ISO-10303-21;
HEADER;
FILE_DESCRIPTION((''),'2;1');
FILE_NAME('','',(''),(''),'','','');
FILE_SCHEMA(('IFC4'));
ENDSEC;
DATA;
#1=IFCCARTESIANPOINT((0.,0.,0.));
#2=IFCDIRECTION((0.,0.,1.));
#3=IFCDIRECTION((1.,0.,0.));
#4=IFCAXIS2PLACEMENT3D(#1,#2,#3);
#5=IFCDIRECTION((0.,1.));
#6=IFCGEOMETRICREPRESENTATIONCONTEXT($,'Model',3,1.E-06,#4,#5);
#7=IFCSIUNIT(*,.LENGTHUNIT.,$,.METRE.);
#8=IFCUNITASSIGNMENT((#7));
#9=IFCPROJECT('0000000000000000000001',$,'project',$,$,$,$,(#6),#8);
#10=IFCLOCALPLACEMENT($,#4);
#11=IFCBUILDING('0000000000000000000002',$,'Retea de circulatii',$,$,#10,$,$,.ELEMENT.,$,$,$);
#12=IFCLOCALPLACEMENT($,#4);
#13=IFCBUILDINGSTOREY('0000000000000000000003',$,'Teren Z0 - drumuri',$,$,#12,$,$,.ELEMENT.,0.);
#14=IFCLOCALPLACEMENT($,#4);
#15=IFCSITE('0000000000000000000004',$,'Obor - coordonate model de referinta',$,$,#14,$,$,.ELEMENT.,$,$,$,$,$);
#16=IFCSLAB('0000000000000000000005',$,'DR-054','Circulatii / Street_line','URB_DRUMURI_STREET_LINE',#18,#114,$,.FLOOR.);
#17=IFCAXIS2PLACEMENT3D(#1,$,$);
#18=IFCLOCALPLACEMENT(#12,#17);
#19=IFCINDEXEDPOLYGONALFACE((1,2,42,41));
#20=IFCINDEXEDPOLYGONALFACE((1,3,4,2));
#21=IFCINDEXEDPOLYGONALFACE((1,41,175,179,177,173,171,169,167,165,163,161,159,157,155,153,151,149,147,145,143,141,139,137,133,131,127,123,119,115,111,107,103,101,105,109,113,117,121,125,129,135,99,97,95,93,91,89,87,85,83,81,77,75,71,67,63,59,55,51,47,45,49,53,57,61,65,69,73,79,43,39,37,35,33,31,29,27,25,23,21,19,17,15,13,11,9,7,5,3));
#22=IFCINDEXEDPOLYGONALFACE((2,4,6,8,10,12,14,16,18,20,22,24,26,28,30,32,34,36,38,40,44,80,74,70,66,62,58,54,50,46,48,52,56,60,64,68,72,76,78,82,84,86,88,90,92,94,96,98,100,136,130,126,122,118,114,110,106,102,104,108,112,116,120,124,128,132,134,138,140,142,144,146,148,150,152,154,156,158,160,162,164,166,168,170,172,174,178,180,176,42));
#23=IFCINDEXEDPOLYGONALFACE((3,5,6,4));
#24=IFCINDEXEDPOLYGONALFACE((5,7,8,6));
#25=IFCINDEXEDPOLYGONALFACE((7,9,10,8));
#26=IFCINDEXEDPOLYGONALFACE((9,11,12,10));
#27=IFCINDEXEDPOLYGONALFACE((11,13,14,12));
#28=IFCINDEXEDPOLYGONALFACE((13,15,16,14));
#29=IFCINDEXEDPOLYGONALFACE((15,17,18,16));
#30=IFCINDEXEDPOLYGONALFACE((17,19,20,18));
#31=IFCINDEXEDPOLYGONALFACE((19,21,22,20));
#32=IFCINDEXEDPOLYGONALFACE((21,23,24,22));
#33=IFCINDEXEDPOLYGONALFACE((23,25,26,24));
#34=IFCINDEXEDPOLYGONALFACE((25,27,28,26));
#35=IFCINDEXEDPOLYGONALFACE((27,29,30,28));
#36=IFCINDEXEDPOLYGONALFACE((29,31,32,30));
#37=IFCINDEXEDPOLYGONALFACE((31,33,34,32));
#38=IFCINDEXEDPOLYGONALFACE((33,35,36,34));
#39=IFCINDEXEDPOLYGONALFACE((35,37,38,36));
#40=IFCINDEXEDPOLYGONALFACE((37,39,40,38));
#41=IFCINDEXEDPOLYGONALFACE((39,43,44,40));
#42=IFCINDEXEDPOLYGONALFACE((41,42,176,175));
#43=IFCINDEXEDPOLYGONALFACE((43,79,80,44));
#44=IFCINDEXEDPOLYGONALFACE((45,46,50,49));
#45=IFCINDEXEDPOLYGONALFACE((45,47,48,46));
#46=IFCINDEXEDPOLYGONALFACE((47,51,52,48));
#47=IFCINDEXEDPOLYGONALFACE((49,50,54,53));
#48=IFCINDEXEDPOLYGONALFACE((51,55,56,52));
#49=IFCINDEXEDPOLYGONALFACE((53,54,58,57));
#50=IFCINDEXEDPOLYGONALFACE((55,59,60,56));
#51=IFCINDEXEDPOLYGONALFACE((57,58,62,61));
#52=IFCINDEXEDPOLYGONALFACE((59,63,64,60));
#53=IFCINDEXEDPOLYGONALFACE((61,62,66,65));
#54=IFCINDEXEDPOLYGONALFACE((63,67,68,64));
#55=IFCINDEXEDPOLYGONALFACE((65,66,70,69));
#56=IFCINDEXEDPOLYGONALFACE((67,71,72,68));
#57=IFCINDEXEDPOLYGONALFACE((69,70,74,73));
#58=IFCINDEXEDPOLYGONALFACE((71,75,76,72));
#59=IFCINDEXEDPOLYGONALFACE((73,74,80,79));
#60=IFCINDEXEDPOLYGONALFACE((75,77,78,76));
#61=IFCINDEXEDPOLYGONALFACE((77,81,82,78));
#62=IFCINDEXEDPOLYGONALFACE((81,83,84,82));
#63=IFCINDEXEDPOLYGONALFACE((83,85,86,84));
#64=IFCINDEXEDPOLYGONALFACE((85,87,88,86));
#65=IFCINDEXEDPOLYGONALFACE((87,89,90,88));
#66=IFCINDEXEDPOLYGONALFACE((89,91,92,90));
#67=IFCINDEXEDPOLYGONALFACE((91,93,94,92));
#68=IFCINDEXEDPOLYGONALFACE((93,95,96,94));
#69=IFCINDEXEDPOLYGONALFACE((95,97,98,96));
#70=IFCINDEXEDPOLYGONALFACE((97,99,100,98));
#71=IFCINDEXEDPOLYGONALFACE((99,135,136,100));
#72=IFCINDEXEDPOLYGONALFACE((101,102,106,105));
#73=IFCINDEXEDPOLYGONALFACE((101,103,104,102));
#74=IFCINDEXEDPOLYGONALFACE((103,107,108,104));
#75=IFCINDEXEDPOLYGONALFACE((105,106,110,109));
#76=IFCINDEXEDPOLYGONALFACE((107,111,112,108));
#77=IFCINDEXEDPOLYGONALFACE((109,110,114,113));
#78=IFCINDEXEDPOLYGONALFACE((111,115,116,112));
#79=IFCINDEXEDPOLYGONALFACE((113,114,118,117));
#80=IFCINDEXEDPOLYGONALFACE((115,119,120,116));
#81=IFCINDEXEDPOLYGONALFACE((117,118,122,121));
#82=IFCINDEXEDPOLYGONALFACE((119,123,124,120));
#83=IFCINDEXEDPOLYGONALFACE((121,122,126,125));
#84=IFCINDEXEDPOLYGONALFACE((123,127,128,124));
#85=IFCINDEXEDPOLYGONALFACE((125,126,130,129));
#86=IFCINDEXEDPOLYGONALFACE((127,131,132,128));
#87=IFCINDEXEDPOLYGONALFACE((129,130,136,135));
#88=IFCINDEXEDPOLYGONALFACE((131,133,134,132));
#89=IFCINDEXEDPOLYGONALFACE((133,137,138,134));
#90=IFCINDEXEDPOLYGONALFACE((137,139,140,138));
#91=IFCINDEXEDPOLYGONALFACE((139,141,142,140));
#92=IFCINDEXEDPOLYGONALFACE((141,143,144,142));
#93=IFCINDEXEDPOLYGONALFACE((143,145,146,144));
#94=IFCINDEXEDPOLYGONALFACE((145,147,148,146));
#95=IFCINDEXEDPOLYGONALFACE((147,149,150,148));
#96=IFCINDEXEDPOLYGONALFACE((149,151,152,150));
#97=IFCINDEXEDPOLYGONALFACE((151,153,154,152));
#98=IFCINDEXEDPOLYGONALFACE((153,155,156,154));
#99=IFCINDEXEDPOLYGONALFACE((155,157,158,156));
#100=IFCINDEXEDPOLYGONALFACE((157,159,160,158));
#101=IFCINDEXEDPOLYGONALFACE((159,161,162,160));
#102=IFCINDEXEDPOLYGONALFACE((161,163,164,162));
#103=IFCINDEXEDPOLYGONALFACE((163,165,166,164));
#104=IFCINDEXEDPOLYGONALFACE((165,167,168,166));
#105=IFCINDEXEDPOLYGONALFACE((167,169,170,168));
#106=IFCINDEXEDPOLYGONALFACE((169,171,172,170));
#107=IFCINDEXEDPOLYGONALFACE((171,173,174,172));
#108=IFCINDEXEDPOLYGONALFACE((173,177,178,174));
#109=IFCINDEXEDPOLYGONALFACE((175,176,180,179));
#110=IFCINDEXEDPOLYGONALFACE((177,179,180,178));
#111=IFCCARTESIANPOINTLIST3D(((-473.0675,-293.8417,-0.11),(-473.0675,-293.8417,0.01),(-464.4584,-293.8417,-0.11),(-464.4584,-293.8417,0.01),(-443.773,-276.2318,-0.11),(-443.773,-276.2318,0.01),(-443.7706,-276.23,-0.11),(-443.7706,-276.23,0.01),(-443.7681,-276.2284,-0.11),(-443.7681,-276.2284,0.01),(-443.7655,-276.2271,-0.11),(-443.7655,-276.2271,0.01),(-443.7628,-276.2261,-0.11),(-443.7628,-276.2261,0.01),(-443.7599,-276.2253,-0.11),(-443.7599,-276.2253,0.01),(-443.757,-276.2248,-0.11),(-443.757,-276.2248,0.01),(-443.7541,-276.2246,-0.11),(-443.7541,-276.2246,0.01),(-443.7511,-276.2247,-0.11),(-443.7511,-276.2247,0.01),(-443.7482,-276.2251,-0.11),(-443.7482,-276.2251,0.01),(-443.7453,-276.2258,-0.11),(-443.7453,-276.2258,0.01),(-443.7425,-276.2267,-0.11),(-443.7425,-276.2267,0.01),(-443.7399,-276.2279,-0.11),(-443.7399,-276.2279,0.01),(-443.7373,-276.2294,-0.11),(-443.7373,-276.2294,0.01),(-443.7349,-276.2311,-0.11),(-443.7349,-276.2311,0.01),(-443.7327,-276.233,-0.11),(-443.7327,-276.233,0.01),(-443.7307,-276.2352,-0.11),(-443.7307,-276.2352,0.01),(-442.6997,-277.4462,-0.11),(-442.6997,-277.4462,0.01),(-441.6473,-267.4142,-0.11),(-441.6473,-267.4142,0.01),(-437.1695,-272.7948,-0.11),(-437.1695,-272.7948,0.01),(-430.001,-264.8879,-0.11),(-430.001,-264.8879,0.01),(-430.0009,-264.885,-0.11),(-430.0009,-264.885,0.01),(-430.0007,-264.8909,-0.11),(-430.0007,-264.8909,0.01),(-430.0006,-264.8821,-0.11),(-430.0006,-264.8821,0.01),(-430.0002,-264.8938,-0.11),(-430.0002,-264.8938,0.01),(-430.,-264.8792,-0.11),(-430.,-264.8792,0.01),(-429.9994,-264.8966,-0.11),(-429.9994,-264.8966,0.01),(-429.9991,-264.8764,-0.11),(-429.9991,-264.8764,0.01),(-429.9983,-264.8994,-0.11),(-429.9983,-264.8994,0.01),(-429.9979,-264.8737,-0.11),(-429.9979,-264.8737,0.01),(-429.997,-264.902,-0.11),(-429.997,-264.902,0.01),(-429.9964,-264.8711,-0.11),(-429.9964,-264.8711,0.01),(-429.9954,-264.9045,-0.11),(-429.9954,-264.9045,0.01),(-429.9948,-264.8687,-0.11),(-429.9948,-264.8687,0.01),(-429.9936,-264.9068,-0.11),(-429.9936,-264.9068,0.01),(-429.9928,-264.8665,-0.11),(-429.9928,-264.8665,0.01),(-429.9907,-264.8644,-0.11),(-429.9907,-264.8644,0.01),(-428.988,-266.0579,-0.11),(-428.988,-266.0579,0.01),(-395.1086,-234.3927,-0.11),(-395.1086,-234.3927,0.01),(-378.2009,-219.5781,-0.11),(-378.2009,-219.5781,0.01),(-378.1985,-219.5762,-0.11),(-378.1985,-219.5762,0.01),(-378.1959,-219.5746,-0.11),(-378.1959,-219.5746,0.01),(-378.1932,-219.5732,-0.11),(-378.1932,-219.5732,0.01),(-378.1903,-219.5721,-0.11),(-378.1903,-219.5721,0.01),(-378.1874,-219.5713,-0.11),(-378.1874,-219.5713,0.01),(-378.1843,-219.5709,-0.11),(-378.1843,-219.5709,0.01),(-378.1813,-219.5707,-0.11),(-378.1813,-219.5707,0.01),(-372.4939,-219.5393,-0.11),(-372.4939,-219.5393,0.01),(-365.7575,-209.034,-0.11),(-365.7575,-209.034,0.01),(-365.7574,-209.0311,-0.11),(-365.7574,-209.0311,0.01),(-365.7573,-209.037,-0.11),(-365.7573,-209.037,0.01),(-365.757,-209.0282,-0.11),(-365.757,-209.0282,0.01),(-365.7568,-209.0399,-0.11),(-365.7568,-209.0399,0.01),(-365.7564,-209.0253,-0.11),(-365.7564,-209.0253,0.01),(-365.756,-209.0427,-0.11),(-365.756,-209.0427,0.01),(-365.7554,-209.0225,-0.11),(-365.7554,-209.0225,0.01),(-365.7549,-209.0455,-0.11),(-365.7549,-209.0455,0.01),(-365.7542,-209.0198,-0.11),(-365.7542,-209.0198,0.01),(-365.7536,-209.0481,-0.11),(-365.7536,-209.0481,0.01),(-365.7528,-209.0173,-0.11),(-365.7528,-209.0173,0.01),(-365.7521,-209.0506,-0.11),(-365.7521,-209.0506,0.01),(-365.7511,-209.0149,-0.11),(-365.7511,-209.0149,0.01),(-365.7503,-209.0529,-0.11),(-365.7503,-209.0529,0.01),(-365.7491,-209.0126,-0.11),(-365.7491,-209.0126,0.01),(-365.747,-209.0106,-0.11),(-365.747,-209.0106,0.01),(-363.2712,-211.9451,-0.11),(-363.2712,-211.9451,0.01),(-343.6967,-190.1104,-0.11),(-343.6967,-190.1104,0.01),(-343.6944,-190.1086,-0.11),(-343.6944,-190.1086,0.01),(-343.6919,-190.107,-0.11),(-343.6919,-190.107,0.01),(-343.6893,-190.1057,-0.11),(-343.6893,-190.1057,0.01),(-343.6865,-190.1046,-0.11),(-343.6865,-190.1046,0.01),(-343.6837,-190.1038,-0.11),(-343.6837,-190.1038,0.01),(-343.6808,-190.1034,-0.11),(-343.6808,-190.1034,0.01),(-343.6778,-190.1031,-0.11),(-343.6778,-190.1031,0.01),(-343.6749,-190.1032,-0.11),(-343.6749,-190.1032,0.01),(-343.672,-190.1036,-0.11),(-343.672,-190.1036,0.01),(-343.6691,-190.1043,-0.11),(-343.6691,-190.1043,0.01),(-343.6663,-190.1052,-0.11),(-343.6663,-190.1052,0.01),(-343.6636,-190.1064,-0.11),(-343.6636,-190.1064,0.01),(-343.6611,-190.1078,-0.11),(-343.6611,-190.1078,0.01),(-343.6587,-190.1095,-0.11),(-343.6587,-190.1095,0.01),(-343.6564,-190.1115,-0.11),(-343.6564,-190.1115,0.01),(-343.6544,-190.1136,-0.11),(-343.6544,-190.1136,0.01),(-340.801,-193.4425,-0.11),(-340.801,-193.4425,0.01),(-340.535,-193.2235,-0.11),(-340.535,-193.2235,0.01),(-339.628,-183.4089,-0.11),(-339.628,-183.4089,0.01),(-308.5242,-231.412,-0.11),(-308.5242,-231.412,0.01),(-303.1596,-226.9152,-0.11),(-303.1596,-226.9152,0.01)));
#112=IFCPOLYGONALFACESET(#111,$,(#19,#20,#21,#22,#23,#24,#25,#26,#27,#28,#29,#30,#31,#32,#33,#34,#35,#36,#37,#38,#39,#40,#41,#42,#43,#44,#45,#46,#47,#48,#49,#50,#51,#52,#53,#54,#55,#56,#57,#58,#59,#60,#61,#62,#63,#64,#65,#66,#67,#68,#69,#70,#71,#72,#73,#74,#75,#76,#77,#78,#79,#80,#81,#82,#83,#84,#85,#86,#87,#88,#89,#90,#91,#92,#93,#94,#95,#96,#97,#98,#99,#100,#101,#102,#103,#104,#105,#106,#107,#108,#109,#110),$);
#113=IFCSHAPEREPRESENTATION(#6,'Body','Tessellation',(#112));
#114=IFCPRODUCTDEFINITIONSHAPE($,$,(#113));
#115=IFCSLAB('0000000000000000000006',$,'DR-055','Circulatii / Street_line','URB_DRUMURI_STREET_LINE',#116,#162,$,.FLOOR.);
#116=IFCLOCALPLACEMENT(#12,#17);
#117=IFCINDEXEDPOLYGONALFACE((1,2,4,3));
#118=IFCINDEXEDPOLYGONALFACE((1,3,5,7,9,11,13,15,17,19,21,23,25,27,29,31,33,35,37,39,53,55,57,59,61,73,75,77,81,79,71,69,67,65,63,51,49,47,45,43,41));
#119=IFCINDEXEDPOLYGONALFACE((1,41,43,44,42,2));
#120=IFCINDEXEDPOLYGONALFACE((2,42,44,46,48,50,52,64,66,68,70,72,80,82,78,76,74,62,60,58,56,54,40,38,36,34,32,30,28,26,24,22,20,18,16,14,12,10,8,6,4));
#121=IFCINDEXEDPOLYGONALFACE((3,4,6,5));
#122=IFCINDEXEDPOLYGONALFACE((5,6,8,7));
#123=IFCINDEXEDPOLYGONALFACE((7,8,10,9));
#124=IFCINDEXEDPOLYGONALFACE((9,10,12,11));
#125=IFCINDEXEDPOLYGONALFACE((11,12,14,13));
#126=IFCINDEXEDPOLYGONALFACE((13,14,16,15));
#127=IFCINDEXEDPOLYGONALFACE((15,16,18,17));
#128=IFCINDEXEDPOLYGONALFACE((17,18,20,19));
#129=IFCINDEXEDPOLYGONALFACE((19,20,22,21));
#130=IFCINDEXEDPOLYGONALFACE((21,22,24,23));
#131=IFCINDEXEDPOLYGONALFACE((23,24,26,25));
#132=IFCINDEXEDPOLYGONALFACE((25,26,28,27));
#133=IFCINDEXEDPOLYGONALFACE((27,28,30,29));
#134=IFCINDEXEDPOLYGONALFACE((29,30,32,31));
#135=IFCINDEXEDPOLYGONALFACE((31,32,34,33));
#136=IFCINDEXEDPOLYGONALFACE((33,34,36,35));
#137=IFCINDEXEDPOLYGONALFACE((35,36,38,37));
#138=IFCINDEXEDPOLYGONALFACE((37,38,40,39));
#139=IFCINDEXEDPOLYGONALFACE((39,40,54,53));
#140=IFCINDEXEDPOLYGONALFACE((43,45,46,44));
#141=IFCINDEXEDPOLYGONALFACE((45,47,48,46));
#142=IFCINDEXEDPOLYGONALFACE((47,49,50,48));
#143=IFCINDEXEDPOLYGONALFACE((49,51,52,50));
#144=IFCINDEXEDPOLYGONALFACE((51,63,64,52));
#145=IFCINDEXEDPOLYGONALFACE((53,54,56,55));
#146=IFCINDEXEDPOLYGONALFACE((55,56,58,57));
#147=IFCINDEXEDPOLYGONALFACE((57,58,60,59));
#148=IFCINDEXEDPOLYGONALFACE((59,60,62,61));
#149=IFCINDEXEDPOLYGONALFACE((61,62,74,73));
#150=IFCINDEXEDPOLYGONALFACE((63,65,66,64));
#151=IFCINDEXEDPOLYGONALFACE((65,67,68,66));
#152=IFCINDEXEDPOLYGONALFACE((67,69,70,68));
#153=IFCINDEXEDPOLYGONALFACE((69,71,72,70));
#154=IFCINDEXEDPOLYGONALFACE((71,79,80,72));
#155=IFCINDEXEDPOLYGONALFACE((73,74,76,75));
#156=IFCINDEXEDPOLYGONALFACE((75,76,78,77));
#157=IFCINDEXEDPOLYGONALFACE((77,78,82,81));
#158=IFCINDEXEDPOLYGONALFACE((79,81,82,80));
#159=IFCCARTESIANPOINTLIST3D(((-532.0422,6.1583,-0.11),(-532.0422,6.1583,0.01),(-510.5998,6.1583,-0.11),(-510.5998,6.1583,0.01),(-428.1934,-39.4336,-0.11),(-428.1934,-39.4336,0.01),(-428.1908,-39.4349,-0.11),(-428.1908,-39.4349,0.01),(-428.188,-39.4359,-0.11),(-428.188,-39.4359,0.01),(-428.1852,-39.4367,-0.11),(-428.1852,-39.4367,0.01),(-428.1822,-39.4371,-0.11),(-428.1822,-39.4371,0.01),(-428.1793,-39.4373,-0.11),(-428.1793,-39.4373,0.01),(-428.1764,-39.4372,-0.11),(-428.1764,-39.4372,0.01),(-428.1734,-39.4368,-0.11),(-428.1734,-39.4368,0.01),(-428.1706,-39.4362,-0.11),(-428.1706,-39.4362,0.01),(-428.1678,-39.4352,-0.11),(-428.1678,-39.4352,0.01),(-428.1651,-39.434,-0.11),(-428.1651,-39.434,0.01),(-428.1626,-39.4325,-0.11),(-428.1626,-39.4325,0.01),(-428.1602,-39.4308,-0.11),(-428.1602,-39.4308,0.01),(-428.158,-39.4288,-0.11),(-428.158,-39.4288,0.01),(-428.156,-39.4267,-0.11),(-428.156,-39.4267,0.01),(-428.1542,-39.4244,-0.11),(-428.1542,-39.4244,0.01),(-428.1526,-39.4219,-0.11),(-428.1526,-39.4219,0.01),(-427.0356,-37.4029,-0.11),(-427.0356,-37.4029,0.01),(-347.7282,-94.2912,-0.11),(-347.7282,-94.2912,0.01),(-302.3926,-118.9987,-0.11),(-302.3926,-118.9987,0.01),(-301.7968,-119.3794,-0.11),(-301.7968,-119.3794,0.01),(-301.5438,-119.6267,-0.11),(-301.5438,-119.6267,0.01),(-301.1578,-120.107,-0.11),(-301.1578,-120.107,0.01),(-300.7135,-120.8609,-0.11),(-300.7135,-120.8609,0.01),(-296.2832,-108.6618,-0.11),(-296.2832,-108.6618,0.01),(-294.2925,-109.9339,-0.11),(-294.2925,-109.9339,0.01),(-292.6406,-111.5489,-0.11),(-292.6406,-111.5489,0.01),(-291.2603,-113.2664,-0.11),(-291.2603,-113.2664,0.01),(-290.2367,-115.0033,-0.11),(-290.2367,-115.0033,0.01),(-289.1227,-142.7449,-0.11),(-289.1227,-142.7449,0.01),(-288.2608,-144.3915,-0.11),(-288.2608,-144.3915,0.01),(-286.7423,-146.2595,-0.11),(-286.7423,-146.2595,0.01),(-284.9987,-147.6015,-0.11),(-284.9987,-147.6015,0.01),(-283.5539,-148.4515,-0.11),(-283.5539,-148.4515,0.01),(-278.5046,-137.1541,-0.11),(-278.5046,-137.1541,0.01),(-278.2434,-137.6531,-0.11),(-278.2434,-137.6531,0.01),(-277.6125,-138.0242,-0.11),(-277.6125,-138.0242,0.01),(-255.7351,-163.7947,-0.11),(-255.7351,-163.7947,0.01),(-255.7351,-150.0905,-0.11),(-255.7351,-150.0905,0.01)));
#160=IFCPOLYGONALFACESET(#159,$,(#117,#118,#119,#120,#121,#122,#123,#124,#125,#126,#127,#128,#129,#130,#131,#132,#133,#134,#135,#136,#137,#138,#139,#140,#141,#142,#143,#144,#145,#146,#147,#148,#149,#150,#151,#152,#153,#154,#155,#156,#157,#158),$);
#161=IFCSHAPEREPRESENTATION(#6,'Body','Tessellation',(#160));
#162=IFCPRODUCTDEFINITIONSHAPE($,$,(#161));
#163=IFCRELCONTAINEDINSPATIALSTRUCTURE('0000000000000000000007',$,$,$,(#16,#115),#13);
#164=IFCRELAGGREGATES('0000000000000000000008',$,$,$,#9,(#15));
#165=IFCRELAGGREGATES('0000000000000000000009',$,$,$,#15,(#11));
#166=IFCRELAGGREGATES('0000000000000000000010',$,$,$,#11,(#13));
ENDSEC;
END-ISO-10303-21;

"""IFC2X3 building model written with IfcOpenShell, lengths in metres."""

from ifc_helpers import new_model, si_unit, direction, frame, origin_with_axes, place, context, project, spatial, polyline, outline, extrude, element, save


model = new_model("IFC2X3")

# Units and contexts
model_context = context("Model", 3, precision=1e-06, world=origin_with_axes(), true_north=direction((0.0, 1.0)))
ifc_project = project(units=[si_unit("LENGTHUNIT", "METRE")], contexts=[model_context])

# Site, building, storey
site_placement = place(None, origin_with_axes())
site = spatial("IfcSite", under=ifc_project, at=site_placement, Name="Obor - coordonate model de referinta", CompositionType="ELEMENT")
building_placement = place(None, origin_with_axes())
building = spatial("IfcBuilding", under=site, at=building_placement, Name="Retea de circulatii", CompositionType="ELEMENT")
storey_placement = place(None, origin_with_axes())
storey = spatial("IfcBuildingStorey", under=building, at=storey_placement, Name="Teren Z0 - drumuri", CompositionType="ELEMENT", Elevation=0.0)

# Slabs
slab_1_placement = place(None, origin_with_axes())
element("IfcSlab", 1, at=slab_1_placement, inside=storey, Name="DR-054", Description="Circulatii / Street_line", ObjectType="URB_DRUMURI_STREET_LINE", PredefinedType="FLOOR", context=model_context, shape_type="SweptSolid", body=[
    extrude(outline(polyline([(-339.628, -183.4089), (-441.6473, -267.4142), (-473.0675, -293.8417), (-464.4584, -293.8417), (-443.773, -276.2318), (-443.7706, -276.23), (-443.7681, -276.2284), (-443.7655, -276.2271), (-443.7628, -276.2261), (-443.7599, -276.2253), (-443.757, -276.2248), (-443.7541, -276.2246), (-443.7511, -276.2247), (-443.7482, -276.2251), (-443.7453, -276.2258), (-443.7425, -276.2267), (-443.7399, -276.2279), (-443.7373, -276.2294), (-443.7349, -276.2311), (-443.7327, -276.233), (-443.7307, -276.2352), (-442.6997, -277.4462), (-437.1695, -272.7948), (-428.988, -266.0579), (-429.9936, -264.9068), (-429.9954, -264.9045), (-429.997, -264.902), (-429.9983, -264.8994), (-429.9994, -264.8966), (-430.0002, -264.8938), (-430.0007, -264.8909), (-430.001, -264.8879), (-430.0009, -264.885), (-430.0006, -264.8821), (-430.0, -264.8792), (-429.9991, -264.8764), (-429.9979, -264.8737), (-429.9964, -264.8711), (-429.9948, -264.8687), (-429.9928, -264.8665), (-429.9907, -264.8644), (-395.1086, -234.3927), (-378.2009, -219.5781), (-378.1985, -219.5762), (-378.1959, -219.5746), (-378.1932, -219.5732), (-378.1903, -219.5721), (-378.1874, -219.5713), (-378.1843, -219.5709), (-378.1813, -219.5707), (-372.4939, -219.5393), (-363.2712, -211.9451), (-365.7503, -209.0529), (-365.7521, -209.0506), (-365.7536, -209.0481), (-365.7549, -209.0455), (-365.756, -209.0427), (-365.7568, -209.0399), (-365.7573, -209.037), (-365.7575, -209.034), (-365.7574, -209.0311), (-365.757, -209.0282), (-365.7564, -209.0253), (-365.7554, -209.0225), (-365.7542, -209.0198), (-365.7528, -209.0173), (-365.7511, -209.0149), (-365.7491, -209.0126), (-365.747, -209.0106), (-343.6967, -190.1104), (-343.6944, -190.1086), (-343.6919, -190.107), (-343.6893, -190.1057), (-343.6865, -190.1046), (-343.6837, -190.1038), (-343.6808, -190.1034), (-343.6778, -190.1031), (-343.6749, -190.1032), (-343.672, -190.1036), (-343.6691, -190.1043), (-343.6663, -190.1052), (-343.6636, -190.1064), (-343.6611, -190.1078), (-343.6587, -190.1095), (-343.6564, -190.1115), (-343.6544, -190.1136), (-340.801, -193.4425), (-340.535, -193.2235), (-308.5242, -231.412), (-303.1596, -226.9152), (-339.628, -183.4089)])), frame((0.0, 0.0, -0.11), z_axis=(0.0, 0.0, 1.0), x_axis=(1.0, 0.0, 0.0)), (0.0, 0.0, 1.0), 0.12),
])
slab_2_placement = place(None, origin_with_axes())
element("IfcSlab", 2, at=slab_2_placement, inside=storey, Name="DR-055", Description="Circulatii / Street_line", ObjectType="URB_DRUMURI_STREET_LINE", PredefinedType="FLOOR", context=model_context, shape_type="SweptSolid", body=[
    extrude(outline(polyline([(-284.9987, -147.6015), (-283.5539, -148.4515), (-255.7351, -163.7947), (-255.7351, -150.0905), (-277.6125, -138.0242), (-278.2434, -137.6531), (-278.5046, -137.1541), (-290.2367, -115.0033), (-291.2603, -113.2664), (-292.6406, -111.5489), (-294.2925, -109.9339), (-296.2832, -108.6618), (-427.0356, -37.4029), (-428.1526, -39.4219), (-428.1542, -39.4244), (-428.156, -39.4267), (-428.158, -39.4288), (-428.1602, -39.4308), (-428.1626, -39.4325), (-428.1651, -39.434), (-428.1678, -39.4352), (-428.1706, -39.4362), (-428.1734, -39.4368), (-428.1764, -39.4372), (-428.1793, -39.4373), (-428.1822, -39.4371), (-428.1852, -39.4367), (-428.188, -39.4359), (-428.1908, -39.4349), (-428.1934, -39.4336), (-510.5998, 6.1583), (-532.0422, 6.1583), (-347.7282, -94.2912), (-302.3926, -118.9987), (-301.7968, -119.3794), (-301.5438, -119.6267), (-301.1578, -120.107), (-300.7135, -120.8609), (-289.1227, -142.7449), (-288.2608, -144.3915), (-286.7423, -146.2595), (-284.9987, -147.6015)])), frame((0.0, 0.0, -0.11), z_axis=(0.0, 0.0, 1.0), x_axis=(1.0, 0.0, 0.0)), (0.0, 0.0, 1.0), 0.12),
])

save(model, "model.ifc")
